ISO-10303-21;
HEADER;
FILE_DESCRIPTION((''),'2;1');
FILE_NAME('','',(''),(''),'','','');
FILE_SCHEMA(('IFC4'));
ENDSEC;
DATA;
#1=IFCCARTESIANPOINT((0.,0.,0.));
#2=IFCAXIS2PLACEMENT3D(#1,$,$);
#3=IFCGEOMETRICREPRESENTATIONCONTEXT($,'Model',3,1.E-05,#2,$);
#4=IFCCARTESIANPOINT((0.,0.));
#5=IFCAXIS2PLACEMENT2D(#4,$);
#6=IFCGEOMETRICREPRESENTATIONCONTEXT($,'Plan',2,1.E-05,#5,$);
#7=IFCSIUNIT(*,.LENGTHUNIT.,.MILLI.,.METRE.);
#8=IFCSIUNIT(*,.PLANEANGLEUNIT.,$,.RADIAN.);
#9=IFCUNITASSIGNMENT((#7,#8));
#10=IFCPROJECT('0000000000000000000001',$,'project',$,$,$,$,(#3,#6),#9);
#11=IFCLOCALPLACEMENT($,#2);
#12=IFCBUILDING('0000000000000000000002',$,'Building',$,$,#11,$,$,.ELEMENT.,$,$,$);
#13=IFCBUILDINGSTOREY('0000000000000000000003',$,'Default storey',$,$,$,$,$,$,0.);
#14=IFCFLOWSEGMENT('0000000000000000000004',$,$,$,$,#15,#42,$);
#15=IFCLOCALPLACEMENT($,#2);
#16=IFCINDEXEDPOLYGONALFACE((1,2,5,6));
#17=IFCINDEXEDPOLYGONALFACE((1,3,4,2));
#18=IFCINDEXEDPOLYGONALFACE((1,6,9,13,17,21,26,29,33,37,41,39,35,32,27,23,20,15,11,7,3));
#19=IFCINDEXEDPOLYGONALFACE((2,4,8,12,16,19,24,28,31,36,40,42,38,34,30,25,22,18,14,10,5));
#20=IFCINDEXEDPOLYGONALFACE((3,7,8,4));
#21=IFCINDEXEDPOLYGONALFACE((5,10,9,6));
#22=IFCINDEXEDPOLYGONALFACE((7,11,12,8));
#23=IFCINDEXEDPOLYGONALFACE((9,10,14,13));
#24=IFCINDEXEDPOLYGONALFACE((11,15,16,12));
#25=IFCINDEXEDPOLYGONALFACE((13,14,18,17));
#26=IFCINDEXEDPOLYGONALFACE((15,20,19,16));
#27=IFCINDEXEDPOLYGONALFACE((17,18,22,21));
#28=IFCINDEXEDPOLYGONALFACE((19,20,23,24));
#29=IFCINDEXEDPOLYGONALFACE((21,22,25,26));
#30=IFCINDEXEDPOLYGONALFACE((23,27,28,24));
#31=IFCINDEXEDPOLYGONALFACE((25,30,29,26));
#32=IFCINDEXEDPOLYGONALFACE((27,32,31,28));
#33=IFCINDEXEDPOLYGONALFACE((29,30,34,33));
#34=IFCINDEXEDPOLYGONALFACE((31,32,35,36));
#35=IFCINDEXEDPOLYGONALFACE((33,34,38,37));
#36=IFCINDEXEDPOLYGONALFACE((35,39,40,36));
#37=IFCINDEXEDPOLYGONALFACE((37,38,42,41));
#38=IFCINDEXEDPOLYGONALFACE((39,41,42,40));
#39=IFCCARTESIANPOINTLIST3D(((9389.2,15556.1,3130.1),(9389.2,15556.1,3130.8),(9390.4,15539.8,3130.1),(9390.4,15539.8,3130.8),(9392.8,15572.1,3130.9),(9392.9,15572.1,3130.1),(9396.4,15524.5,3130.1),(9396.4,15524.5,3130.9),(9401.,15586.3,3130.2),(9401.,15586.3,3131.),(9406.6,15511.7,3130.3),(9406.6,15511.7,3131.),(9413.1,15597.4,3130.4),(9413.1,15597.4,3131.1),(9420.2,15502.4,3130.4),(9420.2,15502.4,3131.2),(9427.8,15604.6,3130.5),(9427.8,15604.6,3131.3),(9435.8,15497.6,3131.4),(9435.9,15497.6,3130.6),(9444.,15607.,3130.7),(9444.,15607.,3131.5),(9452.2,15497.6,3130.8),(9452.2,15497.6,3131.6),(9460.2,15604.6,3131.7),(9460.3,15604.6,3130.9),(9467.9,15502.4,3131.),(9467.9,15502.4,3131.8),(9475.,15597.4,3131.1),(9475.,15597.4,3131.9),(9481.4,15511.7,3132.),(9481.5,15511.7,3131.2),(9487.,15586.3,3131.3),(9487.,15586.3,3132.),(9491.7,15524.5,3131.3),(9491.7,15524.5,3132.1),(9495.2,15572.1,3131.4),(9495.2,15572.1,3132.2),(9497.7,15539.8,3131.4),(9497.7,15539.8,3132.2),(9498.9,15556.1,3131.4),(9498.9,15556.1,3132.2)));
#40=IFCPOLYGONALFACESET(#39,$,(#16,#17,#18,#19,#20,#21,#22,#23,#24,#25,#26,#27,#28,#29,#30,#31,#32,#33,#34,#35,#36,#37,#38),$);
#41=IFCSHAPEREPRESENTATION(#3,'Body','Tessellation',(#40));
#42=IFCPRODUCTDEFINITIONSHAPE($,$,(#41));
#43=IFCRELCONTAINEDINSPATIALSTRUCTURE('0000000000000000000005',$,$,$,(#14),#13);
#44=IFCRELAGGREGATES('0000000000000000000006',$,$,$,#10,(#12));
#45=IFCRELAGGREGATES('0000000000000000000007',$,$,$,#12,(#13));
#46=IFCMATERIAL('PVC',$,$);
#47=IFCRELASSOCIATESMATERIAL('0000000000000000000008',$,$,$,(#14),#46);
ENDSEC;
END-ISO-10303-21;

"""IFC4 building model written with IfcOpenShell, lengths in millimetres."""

from ifc_helpers import new_model, si_unit, frame, origin, origin_2d, place, context, project, spatial, circle, extrude, material, element, save


model = new_model("IFC4")

# Units and contexts
model_context = context("Model", 3, precision=1e-05, world=origin())
plan_context = context("Plan", 2, precision=1e-05, world=origin_2d())
ifc_project = project(units=[si_unit("LENGTHUNIT", "METRE", prefix="MILLI"), si_unit("PLANEANGLEUNIT", "RADIAN")], contexts=[model_context, plan_context])

# Building, storey
placement = place(None, origin())
building = spatial("IfcBuilding", under=ifc_project, at=placement, Name="Building", CompositionType="ELEMENT")
storey = spatial("IfcBuildingStorey", under=building, Name="Default storey", Elevation=0.0)

# Flow segment
ifc_material_1 = material(Name="PVC")
element("IfcFlowSegment", 1, at=placement, inside=storey, material=ifc_material_1, context=model_context, shape_type="SweptSolid", body=[
    extrude(circle(Radius=55.0, at=origin_2d()), frame((9444.0, 15552.0, 3130.7), z_axis=(-0.009623, 0.0, 0.765065), x_axis=(0.0, 9.623462, 0.0)), (0.0, 0.0, 1.0), 0.8),
])

save(model, "model.ifc")
